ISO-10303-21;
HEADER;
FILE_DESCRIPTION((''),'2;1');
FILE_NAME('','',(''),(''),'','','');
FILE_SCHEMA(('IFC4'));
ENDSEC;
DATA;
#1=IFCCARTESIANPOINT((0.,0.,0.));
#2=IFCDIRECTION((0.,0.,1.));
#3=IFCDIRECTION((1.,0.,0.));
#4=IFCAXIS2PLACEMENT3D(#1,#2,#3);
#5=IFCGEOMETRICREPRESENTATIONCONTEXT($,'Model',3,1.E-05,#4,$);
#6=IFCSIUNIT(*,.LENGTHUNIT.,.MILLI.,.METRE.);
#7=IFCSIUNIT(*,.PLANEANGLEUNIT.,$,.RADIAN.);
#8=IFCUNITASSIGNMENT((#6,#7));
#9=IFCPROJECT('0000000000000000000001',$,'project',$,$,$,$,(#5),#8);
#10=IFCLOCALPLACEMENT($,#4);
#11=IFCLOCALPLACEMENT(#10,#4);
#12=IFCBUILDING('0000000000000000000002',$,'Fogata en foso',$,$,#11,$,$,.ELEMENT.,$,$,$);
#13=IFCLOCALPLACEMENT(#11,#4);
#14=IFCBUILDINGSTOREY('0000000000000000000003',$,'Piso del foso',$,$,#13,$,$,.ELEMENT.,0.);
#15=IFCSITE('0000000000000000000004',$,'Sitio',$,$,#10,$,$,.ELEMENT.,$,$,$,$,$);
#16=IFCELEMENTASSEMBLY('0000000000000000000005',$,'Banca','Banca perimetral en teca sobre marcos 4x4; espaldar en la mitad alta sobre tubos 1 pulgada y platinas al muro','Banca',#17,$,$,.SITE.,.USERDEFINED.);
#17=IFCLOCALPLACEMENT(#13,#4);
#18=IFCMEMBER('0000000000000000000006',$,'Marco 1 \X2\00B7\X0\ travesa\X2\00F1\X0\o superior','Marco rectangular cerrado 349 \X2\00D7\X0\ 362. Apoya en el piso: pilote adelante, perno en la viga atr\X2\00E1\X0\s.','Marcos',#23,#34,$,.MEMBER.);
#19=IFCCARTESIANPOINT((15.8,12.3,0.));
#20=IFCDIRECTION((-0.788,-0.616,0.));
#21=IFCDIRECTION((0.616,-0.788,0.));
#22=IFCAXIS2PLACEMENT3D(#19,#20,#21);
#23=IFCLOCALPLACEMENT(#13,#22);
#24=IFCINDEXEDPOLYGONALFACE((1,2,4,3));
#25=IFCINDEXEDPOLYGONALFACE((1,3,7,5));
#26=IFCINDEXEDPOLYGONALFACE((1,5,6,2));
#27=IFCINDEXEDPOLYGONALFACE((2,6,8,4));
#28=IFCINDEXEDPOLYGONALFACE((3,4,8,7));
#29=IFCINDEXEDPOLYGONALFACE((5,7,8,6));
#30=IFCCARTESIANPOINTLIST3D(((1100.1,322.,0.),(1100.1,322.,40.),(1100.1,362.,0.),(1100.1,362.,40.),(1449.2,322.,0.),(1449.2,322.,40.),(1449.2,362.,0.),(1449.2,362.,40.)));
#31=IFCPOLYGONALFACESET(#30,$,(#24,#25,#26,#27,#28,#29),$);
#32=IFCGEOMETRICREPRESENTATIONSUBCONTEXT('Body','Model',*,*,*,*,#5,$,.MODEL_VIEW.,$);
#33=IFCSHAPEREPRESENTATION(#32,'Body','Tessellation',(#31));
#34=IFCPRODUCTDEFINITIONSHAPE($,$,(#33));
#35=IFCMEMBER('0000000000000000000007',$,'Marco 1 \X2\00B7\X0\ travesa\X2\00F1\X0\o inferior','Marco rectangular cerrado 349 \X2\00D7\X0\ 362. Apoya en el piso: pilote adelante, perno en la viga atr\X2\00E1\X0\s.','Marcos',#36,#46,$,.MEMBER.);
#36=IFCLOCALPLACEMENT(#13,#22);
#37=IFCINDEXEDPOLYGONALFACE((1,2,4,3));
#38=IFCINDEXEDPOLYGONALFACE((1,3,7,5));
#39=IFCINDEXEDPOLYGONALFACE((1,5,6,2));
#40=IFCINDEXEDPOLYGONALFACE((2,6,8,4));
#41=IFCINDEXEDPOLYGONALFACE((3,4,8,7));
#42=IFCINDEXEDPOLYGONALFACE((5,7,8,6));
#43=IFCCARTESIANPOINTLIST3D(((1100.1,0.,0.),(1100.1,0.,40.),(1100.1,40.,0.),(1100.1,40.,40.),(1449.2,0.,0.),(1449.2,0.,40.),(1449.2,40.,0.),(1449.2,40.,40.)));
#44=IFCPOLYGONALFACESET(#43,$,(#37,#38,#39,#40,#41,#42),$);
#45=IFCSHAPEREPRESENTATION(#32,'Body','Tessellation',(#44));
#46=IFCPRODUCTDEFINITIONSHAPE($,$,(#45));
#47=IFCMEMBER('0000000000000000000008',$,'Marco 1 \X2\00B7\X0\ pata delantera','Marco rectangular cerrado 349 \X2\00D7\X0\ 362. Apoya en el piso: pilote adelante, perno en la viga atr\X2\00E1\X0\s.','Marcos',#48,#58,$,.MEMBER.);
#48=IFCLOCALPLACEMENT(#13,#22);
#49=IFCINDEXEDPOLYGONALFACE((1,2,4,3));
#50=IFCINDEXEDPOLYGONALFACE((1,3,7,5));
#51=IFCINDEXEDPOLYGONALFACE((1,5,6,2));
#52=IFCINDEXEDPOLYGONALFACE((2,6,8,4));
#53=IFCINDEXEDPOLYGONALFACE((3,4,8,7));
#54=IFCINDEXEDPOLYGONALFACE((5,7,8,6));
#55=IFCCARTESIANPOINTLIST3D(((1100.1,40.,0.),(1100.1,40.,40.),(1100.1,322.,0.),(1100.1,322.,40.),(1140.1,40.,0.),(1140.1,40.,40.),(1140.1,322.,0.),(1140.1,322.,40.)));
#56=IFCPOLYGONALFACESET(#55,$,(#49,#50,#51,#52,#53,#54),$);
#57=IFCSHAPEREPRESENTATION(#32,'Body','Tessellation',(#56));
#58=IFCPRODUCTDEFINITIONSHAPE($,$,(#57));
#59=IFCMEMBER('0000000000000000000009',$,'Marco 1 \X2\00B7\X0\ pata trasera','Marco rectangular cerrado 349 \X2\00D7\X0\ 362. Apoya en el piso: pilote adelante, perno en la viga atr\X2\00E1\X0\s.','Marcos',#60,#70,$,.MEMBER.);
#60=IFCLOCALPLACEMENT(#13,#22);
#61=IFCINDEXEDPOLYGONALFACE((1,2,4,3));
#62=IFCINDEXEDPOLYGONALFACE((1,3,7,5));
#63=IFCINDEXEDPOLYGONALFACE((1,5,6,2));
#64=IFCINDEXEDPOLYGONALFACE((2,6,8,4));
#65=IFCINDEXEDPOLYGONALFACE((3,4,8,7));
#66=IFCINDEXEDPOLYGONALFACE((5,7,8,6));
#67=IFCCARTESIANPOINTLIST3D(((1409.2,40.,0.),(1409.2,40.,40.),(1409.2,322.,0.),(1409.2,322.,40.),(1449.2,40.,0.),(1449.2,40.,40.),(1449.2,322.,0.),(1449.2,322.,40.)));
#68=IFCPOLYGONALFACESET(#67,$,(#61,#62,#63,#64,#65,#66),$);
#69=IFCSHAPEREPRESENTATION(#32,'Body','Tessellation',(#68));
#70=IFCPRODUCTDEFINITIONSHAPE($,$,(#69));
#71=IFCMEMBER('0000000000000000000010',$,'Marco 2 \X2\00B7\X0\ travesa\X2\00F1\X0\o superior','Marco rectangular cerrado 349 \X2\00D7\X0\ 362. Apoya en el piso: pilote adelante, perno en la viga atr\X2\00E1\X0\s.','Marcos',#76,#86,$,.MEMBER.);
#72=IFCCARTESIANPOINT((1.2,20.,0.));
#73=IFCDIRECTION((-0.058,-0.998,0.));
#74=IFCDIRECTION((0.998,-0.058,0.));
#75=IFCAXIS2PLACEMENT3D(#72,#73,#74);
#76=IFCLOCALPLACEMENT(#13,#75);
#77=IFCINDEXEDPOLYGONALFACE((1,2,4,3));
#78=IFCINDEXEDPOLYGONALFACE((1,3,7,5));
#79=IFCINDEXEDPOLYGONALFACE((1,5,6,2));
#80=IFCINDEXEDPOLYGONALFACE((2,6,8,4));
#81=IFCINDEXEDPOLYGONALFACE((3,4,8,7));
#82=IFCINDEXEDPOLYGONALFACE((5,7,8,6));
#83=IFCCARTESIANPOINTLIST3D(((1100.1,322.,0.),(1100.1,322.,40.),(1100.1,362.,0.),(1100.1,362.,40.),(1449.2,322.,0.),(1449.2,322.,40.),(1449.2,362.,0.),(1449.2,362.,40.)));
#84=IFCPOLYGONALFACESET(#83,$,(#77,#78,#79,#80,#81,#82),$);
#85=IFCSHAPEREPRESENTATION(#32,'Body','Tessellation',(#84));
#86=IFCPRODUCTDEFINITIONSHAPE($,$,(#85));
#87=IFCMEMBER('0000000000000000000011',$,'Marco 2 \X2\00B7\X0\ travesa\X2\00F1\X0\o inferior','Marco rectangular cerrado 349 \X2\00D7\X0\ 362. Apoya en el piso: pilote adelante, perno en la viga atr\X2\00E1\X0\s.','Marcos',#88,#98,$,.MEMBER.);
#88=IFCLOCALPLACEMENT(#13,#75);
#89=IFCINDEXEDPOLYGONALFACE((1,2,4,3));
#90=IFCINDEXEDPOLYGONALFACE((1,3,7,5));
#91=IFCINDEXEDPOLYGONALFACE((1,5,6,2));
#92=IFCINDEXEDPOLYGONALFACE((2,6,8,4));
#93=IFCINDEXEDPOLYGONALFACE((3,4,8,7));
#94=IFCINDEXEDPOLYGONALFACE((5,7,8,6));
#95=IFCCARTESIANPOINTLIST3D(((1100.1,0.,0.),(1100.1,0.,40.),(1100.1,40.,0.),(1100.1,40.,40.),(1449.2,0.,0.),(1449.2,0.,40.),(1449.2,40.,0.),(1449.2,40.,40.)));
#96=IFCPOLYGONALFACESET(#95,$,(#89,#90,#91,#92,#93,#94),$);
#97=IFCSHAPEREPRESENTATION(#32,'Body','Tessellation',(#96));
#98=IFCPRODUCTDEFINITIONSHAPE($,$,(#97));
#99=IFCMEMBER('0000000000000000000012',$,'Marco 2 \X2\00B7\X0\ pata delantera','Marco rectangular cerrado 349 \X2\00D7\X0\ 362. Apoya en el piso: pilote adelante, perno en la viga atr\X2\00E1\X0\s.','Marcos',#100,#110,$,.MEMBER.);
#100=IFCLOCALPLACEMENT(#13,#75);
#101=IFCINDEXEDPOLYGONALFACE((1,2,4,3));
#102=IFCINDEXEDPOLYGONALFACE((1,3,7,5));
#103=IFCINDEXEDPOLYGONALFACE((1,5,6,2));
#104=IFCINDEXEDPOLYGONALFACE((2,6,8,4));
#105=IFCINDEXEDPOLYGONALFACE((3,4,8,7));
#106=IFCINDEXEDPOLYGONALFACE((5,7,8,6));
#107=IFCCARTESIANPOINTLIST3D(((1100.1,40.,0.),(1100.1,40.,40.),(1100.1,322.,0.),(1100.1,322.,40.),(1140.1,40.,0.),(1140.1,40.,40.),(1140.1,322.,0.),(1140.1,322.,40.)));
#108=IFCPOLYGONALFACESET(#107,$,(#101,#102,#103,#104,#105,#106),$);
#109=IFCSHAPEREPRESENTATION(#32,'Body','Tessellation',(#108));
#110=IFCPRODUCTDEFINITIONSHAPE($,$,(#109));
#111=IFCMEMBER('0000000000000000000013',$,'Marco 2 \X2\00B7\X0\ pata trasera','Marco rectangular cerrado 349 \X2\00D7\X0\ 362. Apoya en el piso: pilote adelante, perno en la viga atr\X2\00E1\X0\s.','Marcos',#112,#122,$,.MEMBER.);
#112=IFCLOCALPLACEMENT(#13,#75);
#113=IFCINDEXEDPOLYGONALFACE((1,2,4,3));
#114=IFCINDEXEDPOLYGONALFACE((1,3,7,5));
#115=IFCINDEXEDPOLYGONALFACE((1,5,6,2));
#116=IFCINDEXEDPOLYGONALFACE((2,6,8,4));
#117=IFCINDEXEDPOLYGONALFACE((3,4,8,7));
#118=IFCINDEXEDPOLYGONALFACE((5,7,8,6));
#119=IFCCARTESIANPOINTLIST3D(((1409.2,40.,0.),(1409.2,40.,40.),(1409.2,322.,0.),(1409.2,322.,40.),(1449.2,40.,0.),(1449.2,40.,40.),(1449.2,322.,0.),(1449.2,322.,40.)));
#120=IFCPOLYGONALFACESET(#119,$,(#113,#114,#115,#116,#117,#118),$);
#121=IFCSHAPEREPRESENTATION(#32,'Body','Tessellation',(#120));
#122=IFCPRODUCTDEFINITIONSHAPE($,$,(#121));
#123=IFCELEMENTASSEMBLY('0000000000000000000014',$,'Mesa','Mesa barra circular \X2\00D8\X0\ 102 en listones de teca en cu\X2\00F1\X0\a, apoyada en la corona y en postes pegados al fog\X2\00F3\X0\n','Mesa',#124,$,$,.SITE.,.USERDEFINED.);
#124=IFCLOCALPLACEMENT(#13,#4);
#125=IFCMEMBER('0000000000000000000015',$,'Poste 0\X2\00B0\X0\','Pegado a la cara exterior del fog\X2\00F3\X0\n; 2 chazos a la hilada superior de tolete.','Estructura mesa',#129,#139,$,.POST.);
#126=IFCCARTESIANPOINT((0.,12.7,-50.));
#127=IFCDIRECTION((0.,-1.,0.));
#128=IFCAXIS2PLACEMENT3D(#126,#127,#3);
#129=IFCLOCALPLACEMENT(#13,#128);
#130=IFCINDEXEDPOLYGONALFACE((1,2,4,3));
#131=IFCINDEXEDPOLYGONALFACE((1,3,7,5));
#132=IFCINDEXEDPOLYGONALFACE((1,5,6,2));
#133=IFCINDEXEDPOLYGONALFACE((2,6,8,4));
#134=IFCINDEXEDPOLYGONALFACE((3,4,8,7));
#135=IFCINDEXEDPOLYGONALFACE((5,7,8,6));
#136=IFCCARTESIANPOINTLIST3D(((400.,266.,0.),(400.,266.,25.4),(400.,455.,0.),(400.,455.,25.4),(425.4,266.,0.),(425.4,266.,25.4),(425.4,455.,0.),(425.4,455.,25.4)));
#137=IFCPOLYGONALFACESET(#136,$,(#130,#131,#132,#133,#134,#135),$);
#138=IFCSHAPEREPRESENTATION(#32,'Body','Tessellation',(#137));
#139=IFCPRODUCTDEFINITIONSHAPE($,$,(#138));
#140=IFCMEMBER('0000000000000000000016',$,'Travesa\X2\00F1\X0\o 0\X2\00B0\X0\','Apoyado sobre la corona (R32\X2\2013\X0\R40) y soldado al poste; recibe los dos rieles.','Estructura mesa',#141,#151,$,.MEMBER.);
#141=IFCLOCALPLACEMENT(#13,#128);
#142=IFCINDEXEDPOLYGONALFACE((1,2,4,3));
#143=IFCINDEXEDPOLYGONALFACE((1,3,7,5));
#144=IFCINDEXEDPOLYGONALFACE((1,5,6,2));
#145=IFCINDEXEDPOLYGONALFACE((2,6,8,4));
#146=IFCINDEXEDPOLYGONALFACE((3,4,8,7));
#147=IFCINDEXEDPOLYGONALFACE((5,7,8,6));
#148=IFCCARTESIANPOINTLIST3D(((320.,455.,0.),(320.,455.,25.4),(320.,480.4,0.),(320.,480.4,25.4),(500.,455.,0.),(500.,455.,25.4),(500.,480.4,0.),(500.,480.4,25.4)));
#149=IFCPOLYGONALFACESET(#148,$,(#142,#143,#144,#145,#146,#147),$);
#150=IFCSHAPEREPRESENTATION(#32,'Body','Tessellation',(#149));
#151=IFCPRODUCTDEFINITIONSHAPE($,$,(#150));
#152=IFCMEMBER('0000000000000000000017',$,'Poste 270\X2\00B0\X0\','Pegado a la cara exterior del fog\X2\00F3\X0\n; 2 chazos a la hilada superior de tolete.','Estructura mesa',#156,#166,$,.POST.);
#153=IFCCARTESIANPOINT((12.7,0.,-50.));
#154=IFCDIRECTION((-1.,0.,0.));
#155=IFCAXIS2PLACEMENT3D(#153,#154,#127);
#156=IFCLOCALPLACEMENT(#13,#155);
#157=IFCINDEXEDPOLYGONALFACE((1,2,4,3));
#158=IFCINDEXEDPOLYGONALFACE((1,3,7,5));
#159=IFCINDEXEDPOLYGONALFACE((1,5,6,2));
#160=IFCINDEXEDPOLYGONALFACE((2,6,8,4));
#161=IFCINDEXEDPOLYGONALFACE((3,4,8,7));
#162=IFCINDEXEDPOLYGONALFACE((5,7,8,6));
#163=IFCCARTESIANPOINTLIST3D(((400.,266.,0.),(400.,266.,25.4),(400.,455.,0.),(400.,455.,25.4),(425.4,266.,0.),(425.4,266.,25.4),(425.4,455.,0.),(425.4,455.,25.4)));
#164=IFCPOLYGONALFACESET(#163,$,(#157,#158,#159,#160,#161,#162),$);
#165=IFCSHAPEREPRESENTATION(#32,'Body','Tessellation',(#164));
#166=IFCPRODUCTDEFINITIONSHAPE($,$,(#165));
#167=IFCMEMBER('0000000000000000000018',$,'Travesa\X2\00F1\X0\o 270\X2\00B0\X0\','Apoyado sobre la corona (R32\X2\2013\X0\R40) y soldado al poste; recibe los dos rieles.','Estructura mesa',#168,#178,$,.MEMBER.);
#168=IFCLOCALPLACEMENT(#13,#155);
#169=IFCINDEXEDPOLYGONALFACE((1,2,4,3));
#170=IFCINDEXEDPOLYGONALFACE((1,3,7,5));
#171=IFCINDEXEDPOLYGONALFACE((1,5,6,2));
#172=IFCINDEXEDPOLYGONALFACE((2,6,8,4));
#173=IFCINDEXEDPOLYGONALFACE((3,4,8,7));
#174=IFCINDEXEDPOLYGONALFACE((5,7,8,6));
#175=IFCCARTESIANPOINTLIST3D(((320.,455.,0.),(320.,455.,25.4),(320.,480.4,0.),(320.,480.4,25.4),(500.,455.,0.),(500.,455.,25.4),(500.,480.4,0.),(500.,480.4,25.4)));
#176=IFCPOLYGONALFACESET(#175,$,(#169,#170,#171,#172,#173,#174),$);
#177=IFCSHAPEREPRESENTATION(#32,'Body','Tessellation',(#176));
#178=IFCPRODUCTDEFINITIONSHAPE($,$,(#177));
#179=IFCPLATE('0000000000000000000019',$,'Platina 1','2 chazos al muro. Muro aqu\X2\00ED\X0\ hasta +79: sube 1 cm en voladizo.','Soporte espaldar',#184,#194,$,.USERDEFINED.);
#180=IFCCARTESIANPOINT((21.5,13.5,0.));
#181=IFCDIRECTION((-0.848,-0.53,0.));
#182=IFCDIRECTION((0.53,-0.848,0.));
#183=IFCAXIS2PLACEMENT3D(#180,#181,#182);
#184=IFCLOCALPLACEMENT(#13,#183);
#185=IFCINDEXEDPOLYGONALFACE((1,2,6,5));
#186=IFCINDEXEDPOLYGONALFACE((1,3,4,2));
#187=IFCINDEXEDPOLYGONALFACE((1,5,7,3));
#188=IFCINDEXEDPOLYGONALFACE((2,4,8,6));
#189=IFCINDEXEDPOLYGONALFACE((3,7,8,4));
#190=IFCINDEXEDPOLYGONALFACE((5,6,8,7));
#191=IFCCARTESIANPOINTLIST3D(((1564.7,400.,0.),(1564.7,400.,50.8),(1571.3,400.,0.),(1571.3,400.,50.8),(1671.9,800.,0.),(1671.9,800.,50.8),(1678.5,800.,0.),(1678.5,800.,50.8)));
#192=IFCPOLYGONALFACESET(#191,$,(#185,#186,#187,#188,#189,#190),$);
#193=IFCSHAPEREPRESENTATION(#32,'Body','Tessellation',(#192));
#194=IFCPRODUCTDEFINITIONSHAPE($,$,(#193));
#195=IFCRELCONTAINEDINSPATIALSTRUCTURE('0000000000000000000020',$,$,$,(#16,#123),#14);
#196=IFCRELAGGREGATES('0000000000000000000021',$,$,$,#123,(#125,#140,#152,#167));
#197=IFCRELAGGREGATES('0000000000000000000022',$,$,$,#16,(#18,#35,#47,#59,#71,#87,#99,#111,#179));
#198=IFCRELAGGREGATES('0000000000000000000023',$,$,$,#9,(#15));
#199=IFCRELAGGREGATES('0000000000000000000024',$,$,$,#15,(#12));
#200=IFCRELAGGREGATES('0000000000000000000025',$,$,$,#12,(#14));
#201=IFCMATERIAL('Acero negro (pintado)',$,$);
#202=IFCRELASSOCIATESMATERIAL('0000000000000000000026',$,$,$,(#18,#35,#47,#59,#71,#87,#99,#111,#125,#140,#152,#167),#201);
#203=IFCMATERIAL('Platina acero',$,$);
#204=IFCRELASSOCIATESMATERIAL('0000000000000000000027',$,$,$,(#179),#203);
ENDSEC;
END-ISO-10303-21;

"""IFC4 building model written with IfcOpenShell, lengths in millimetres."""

from ifc_helpers import new_model, si_unit, frame, origin_with_axes, place, context, subcontext, project, spatial, polyline, outline, extrude, material, element, aggregate, save


model = new_model("IFC4")

# Units and contexts
model_context = context("Model", 3, precision=1e-05, world=origin_with_axes())
body_context = subcontext(model_context, "Body", "Model", "MODEL_VIEW")
ifc_project = project(units=[si_unit("LENGTHUNIT", "METRE", prefix="MILLI"), si_unit("PLANEANGLEUNIT", "RADIAN")], contexts=[model_context])

# Site, building, storey
site_placement = place(None, origin_with_axes())
site = spatial("IfcSite", under=ifc_project, at=site_placement, Name="Sitio", CompositionType="ELEMENT")
building_placement = place(site_placement, origin_with_axes())
building = spatial("IfcBuilding", under=site, at=building_placement, Name="Fogata en foso", CompositionType="ELEMENT")
storey_placement = place(building_placement, origin_with_axes())
storey = spatial("IfcBuildingStorey", under=building, at=storey_placement, Name="Piso del foso", CompositionType="ELEMENT", Elevation=0.0)

# Element assemblies, members
assembly_1_placement = place(storey_placement, origin_with_axes())
assembly_1 = element("IfcElementAssembly", 1, at=assembly_1_placement, inside=storey, Name="Banca", Description="Banca perimetral en teca sobre marcos 4x4; espaldar en la mitad alta sobre tubos 1 pulgada y platinas al muro", ObjectType="Banca", AssemblyPlace="SITE", PredefinedType="USERDEFINED")
ifc_material_1 = material(Name="Acero negro (pintado)")
member_1_placement = place(storey_placement, frame((15.8, 12.3, 0.0), z_axis=(-0.788, -0.616, 0.0), x_axis=(0.616, -0.788, 0.0)))
member_1 = element("IfcMember", 2, at=member_1_placement, material=ifc_material_1, Name="Marco 1 · travesaño superior", Description="Marco rectangular cerrado 349 × 362. Apoya en el piso: pilote adelante, perno en la viga atrás.", ObjectType="Marcos", PredefinedType="MEMBER", context=body_context, shape_type="SweptSolid", body=[
    extrude(outline(polyline([(1100.1, 322.0), (1449.2, 322.0), (1449.2, 362.0), (1100.1, 362.0), (1100.1, 322.0)])), origin_with_axes(), (0.0, 0.0, 1.0), 40.0),
])
member_2_placement = place(storey_placement, frame((15.8, 12.3, 0.0), z_axis=(-0.788, -0.616, 0.0), x_axis=(0.616, -0.788, 0.0)))
member_2 = element("IfcMember", 3, at=member_2_placement, material=ifc_material_1, Name="Marco 1 · travesaño inferior", Description="Marco rectangular cerrado 349 × 362. Apoya en el piso: pilote adelante, perno en la viga atrás.", ObjectType="Marcos", PredefinedType="MEMBER", context=body_context, shape_type="SweptSolid", body=[
    extrude(outline(polyline([(1100.1, 0.0), (1449.2, 0.0), (1449.2, 40.0), (1100.1, 40.0), (1100.1, 0.0)])), origin_with_axes(), (0.0, 0.0, 1.0), 40.0),
])
member_3_placement = place(storey_placement, frame((15.8, 12.3, 0.0), z_axis=(-0.788, -0.616, 0.0), x_axis=(0.616, -0.788, 0.0)))
member_3 = element("IfcMember", 4, at=member_3_placement, material=ifc_material_1, Name="Marco 1 · pata delantera", Description="Marco rectangular cerrado 349 × 362. Apoya en el piso: pilote adelante, perno en la viga atrás.", ObjectType="Marcos", PredefinedType="MEMBER", context=body_context, shape_type="SweptSolid", body=[
    extrude(outline(polyline([(1100.1, 40.0), (1140.1, 40.0), (1140.1, 322.0), (1100.1, 322.0), (1100.1, 40.0)])), origin_with_axes(), (0.0, 0.0, 1.0), 40.0),
])
member_4_placement = place(storey_placement, frame((15.8, 12.3, 0.0), z_axis=(-0.788, -0.616, 0.0), x_axis=(0.616, -0.788, 0.0)))
member_4 = element("IfcMember", 5, at=member_4_placement, material=ifc_material_1, Name="Marco 1 · pata trasera", Description="Marco rectangular cerrado 349 × 362. Apoya en el piso: pilote adelante, perno en la viga atrás.", ObjectType="Marcos", PredefinedType="MEMBER", context=body_context, shape_type="SweptSolid", body=[
    extrude(outline(polyline([(1409.2, 40.0), (1449.2, 40.0), (1449.2, 322.0), (1409.2, 322.0), (1409.2, 40.0)])), origin_with_axes(), (0.0, 0.0, 1.0), 40.0),
])
member_5_placement = place(storey_placement, frame((1.2, 20.0, 0.0), z_axis=(-0.058, -0.998, 0.0), x_axis=(0.998, -0.058, 0.0)))
member_5 = element("IfcMember", 6, at=member_5_placement, material=ifc_material_1, Name="Marco 2 · travesaño superior", Description="Marco rectangular cerrado 349 × 362. Apoya en el piso: pilote adelante, perno en la viga atrás.", ObjectType="Marcos", PredefinedType="MEMBER", context=body_context, shape_type="SweptSolid", body=[
    extrude(outline(polyline([(1100.1, 322.0), (1449.2, 322.0), (1449.2, 362.0), (1100.1, 362.0), (1100.1, 322.0)])), origin_with_axes(), (0.0, 0.0, 1.0), 40.0),
])
member_6_placement = place(storey_placement, frame((1.2, 20.0, 0.0), z_axis=(-0.058, -0.998, 0.0), x_axis=(0.998, -0.058, 0.0)))
member_6 = element("IfcMember", 7, at=member_6_placement, material=ifc_material_1, Name="Marco 2 · travesaño inferior", Description="Marco rectangular cerrado 349 × 362. Apoya en el piso: pilote adelante, perno en la viga atrás.", ObjectType="Marcos", PredefinedType="MEMBER", context=body_context, shape_type="SweptSolid", body=[
    extrude(outline(polyline([(1100.1, 0.0), (1449.2, 0.0), (1449.2, 40.0), (1100.1, 40.0), (1100.1, 0.0)])), origin_with_axes(), (0.0, 0.0, 1.0), 40.0),
])
member_7_placement = place(storey_placement, frame((1.2, 20.0, 0.0), z_axis=(-0.058, -0.998, 0.0), x_axis=(0.998, -0.058, 0.0)))
member_7 = element("IfcMember", 8, at=member_7_placement, material=ifc_material_1, Name="Marco 2 · pata delantera", Description="Marco rectangular cerrado 349 × 362. Apoya en el piso: pilote adelante, perno en la viga atrás.", ObjectType="Marcos", PredefinedType="MEMBER", context=body_context, shape_type="SweptSolid", body=[
    extrude(outline(polyline([(1100.1, 40.0), (1140.1, 40.0), (1140.1, 322.0), (1100.1, 322.0), (1100.1, 40.0)])), origin_with_axes(), (0.0, 0.0, 1.0), 40.0),
])
member_8_placement = place(storey_placement, frame((1.2, 20.0, 0.0), z_axis=(-0.058, -0.998, 0.0), x_axis=(0.998, -0.058, 0.0)))
member_8 = element("IfcMember", 9, at=member_8_placement, material=ifc_material_1, Name="Marco 2 · pata trasera", Description="Marco rectangular cerrado 349 × 362. Apoya en el piso: pilote adelante, perno en la viga atrás.", ObjectType="Marcos", PredefinedType="MEMBER", context=body_context, shape_type="SweptSolid", body=[
    extrude(outline(polyline([(1409.2, 40.0), (1449.2, 40.0), (1449.2, 322.0), (1409.2, 322.0), (1409.2, 40.0)])), origin_with_axes(), (0.0, 0.0, 1.0), 40.0),
])
assembly_2_placement = place(storey_placement, origin_with_axes())
assembly_2 = element("IfcElementAssembly", 10, at=assembly_2_placement, inside=storey, Name="Mesa", Description="Mesa barra circular Ø 102 en listones de teca en cuña, apoyada en la corona y en postes pegados al fogón", ObjectType="Mesa", AssemblyPlace="SITE", PredefinedType="USERDEFINED")
member_9_placement = place(storey_placement, frame((0.0, 12.7, -50.0), z_axis=(0.0, -1.0, 0.0), x_axis=(1.0, 0.0, 0.0)))
member_9 = element("IfcMember", 11, at=member_9_placement, material=ifc_material_1, Name="Poste 0°", Description="Pegado a la cara exterior del fogón; 2 chazos a la hilada superior de tolete.", ObjectType="Estructura mesa", PredefinedType="POST", context=body_context, shape_type="SweptSolid", body=[
    extrude(outline(polyline([(400.0, 266.0), (425.4, 266.0), (425.4, 455.0), (400.0, 455.0), (400.0, 266.0)])), origin_with_axes(), (0.0, 0.0, 1.0), 25.4),
])
member_10_placement = place(storey_placement, frame((0.0, 12.7, -50.0), z_axis=(0.0, -1.0, 0.0), x_axis=(1.0, 0.0, 0.0)))
member_10 = element("IfcMember", 12, at=member_10_placement, material=ifc_material_1, Name="Travesaño 0°", Description="Apoyado sobre la corona (R32–R40) y soldado al poste; recibe los dos rieles.", ObjectType="Estructura mesa", PredefinedType="MEMBER", context=body_context, shape_type="SweptSolid", body=[
    extrude(outline(polyline([(320.0, 455.0), (500.0, 455.0), (500.0, 480.4), (320.0, 480.4), (320.0, 455.0)])), origin_with_axes(), (0.0, 0.0, 1.0), 25.4),
])
member_11_placement = place(storey_placement, frame((12.7, 0.0, -50.0), z_axis=(-1.0, 0.0, 0.0), x_axis=(0.0, -1.0, 0.0)))
member_11 = element("IfcMember", 13, at=member_11_placement, material=ifc_material_1, Name="Poste 270°", Description="Pegado a la cara exterior del fogón; 2 chazos a la hilada superior de tolete.", ObjectType="Estructura mesa", PredefinedType="POST", context=body_context, shape_type="SweptSolid", body=[
    extrude(outline(polyline([(400.0, 266.0), (425.4, 266.0), (425.4, 455.0), (400.0, 455.0), (400.0, 266.0)])), origin_with_axes(), (0.0, 0.0, 1.0), 25.4),
])
member_12_placement = place(storey_placement, frame((12.7, 0.0, -50.0), z_axis=(-1.0, 0.0, 0.0), x_axis=(0.0, -1.0, 0.0)))
member_12 = element("IfcMember", 14, at=member_12_placement, material=ifc_material_1, Name="Travesaño 270°", Description="Apoyado sobre la corona (R32–R40) y soldado al poste; recibe los dos rieles.", ObjectType="Estructura mesa", PredefinedType="MEMBER", context=body_context, shape_type="SweptSolid", body=[
    extrude(outline(polyline([(320.0, 455.0), (500.0, 455.0), (500.0, 480.4), (320.0, 480.4), (320.0, 455.0)])), origin_with_axes(), (0.0, 0.0, 1.0), 25.4),
])
aggregate(assembly_2, [member_9, member_10, member_11, member_12])

# Plate
ifc_material_2 = material(Name="Platina acero")
plate_1_placement = place(storey_placement, frame((21.5, 13.5, 0.0), z_axis=(-0.848, -0.53, 0.0), x_axis=(0.53, -0.848, 0.0)))
plate_1 = element("IfcPlate", 15, at=plate_1_placement, material=ifc_material_2, Name="Platina 1", Description="2 chazos al muro. Muro aquí hasta +79: sube 1 cm en voladizo.", ObjectType="Soporte espaldar", PredefinedType="USERDEFINED", context=body_context, shape_type="SweptSolid", body=[
    extrude(outline(polyline([(1564.7, 400.0), (1571.3, 400.0), (1678.5, 800.0), (1671.9, 800.0), (1564.7, 400.0)])), origin_with_axes(), (0.0, 0.0, 1.0), 50.8),
])

aggregate(assembly_1, [member_1, member_2, member_3, member_4, member_5, member_6, member_7, member_8, plate_1])

save(model, "model.ifc")
